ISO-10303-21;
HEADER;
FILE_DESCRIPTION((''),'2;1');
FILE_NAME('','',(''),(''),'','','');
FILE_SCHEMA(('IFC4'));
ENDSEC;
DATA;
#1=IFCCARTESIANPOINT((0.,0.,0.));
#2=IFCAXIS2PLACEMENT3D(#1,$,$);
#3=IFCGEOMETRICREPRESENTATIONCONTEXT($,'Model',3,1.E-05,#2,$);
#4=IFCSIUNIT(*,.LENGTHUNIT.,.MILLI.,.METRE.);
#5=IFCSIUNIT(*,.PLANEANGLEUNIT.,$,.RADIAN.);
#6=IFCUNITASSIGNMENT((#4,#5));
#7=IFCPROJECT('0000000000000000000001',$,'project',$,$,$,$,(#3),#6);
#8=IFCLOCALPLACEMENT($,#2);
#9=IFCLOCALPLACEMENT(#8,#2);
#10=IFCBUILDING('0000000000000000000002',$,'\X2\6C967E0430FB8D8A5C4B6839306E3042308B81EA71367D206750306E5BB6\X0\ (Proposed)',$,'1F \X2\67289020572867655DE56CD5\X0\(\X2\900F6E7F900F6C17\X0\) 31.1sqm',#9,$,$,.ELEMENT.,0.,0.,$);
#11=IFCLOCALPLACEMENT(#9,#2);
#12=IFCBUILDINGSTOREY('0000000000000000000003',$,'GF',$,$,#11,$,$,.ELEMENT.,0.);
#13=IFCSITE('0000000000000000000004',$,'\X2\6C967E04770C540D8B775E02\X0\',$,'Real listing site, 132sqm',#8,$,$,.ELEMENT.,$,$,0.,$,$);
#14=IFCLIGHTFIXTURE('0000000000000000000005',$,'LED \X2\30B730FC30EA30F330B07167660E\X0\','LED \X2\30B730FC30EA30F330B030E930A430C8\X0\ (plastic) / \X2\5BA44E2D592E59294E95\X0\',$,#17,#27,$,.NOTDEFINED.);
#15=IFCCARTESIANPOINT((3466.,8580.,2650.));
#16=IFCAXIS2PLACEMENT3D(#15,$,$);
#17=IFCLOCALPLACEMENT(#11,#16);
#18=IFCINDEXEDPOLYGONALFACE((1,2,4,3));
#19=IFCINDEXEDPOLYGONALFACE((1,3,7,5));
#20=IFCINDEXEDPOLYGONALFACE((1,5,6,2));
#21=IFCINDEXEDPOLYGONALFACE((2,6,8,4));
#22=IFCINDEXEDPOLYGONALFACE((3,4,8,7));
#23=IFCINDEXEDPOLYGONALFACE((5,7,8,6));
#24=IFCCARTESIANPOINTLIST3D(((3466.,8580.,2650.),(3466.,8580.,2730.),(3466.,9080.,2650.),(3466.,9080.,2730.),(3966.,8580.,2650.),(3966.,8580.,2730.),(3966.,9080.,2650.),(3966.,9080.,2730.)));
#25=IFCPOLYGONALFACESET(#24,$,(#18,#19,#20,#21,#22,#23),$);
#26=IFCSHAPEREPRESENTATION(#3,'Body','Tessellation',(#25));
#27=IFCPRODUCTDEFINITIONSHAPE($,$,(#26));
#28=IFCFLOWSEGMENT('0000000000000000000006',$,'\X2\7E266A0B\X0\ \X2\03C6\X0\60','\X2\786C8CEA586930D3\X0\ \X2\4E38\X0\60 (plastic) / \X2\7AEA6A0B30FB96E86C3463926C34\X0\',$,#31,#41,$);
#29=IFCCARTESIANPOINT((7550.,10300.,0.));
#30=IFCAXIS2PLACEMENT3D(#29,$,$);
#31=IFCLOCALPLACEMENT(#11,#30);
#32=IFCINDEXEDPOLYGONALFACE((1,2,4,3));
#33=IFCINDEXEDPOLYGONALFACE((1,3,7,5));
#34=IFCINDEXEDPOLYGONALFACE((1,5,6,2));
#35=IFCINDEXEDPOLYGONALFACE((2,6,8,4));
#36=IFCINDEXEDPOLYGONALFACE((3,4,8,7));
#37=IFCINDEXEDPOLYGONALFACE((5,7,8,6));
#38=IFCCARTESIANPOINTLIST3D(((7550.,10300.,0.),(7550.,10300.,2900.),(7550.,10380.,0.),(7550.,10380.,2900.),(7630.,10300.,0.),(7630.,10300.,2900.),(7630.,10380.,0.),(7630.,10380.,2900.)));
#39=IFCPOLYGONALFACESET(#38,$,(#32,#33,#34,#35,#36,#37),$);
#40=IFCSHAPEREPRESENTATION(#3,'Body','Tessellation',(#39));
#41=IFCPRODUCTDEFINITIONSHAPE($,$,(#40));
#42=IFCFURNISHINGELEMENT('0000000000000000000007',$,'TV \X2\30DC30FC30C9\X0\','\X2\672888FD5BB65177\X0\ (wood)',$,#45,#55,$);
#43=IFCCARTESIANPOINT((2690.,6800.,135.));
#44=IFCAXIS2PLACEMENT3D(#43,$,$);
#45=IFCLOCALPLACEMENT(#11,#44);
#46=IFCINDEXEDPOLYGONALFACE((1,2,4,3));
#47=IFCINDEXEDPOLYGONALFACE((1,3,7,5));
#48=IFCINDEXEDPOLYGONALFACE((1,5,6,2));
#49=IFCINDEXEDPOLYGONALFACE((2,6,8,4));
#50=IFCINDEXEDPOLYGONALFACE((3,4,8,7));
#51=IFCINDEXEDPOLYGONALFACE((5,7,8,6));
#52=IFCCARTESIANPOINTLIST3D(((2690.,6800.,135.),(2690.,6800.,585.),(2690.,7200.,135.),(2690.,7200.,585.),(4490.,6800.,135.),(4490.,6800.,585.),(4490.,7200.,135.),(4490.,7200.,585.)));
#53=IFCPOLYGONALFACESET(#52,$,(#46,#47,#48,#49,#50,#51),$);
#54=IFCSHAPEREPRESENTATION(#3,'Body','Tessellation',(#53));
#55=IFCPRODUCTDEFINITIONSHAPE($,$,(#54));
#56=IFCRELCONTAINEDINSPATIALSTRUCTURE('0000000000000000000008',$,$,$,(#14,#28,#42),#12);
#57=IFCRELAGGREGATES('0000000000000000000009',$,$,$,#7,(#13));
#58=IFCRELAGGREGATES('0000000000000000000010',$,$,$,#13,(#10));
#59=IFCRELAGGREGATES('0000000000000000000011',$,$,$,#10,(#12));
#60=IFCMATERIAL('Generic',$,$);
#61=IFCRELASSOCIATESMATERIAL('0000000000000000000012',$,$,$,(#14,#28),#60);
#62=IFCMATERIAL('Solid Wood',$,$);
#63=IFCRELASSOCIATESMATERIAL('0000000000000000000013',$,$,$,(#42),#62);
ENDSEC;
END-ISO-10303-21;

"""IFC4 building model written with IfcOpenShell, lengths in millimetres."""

from ifc_helpers import new_model, si_unit, frame, frame_2d, origin, place, context, project, spatial, rectangle, extrude, material, element, save


model = new_model("IFC4")

# Units and contexts
model_context = context("Model", 3, precision=1e-05, world=origin())
ifc_project = project(units=[si_unit("LENGTHUNIT", "METRE", prefix="MILLI"), si_unit("PLANEANGLEUNIT", "RADIAN")], contexts=[model_context])

# Site, building, storey
site_placement = place(None, origin())
site = spatial("IfcSite", under=ifc_project, at=site_placement, Name="沖縄県名護市", ObjectType="Real listing site, 132sqm", CompositionType="ELEMENT", RefElevation=0.0)
building_placement = place(site_placement, origin())
building = spatial("IfcBuilding", under=site, at=building_placement, Name="沖縄・越屋根のある自然素材の家 (Proposed)", ObjectType="1F 木造在来工法(透湿透気) 31.1sqm", CompositionType="ELEMENT", ElevationOfRefHeight=0.0, ElevationOfTerrain=0.0)
storey_placement = place(building_placement, origin())
storey = spatial("IfcBuildingStorey", under=building, at=storey_placement, Name="GF", CompositionType="ELEMENT", Elevation=0.0)

# Shared definitions
ifc_material_1 = material(Name="Solid Wood")

# Shared definitions
ifc_material_2 = material(Name="Generic")

# Light fixture
light_fixture_1_placement = place(storey_placement, frame((3466.0, 8580.0, 2650.0)))
element("IfcLightFixture", 1, at=light_fixture_1_placement, inside=storey, material=ifc_material_2, Name="LED シーリング照明", Description="LED シーリングライト (plastic) / 室中央天井", PredefinedType="NOTDEFINED", context=model_context, shape_type="SweptSolid", body=[
    extrude(rectangle(XDim=500.0, YDim=500.0, at=frame_2d((250.0, 250.0))), frame((3466.0, 8580.0, 2650.0)), (0.0, 0.0, 1.0), 80.0),
])

# Flow segment
flow_segment_placement = place(storey_placement, frame((7550.0, 10300.0, 0.0)))
element("IfcFlowSegment", 2, at=flow_segment_placement, inside=storey, material=ifc_material_2, Name="縦樋 φ60", Description="硬質塩ビ 丸60 (plastic) / 竪樋・雨水排水", context=model_context, shape_type="SweptSolid", body=[
    extrude(rectangle(XDim=80.0, YDim=80.0, at=frame_2d((40.0, 40.0))), frame((7550.0, 10300.0, 0.0)), (0.0, 0.0, 1.0), 2900.0),
])

# Furnishing element
furnishing_placement = place(storey_placement, frame((2690.0, 6800.0, 135.0)))
element("IfcFurnishingElement", 3, at=furnishing_placement, inside=storey, material=ifc_material_1, Name="TV ボード", Description="木製家具 (wood)", context=model_context, shape_type="SweptSolid", body=[
    extrude(rectangle(XDim=1800.0, YDim=400.0, at=frame_2d((900.0, 200.0))), frame((2690.0, 6800.0, 135.0)), (0.0, 0.0, 1.0), 450.0),
])

save(model, "model.ifc")
